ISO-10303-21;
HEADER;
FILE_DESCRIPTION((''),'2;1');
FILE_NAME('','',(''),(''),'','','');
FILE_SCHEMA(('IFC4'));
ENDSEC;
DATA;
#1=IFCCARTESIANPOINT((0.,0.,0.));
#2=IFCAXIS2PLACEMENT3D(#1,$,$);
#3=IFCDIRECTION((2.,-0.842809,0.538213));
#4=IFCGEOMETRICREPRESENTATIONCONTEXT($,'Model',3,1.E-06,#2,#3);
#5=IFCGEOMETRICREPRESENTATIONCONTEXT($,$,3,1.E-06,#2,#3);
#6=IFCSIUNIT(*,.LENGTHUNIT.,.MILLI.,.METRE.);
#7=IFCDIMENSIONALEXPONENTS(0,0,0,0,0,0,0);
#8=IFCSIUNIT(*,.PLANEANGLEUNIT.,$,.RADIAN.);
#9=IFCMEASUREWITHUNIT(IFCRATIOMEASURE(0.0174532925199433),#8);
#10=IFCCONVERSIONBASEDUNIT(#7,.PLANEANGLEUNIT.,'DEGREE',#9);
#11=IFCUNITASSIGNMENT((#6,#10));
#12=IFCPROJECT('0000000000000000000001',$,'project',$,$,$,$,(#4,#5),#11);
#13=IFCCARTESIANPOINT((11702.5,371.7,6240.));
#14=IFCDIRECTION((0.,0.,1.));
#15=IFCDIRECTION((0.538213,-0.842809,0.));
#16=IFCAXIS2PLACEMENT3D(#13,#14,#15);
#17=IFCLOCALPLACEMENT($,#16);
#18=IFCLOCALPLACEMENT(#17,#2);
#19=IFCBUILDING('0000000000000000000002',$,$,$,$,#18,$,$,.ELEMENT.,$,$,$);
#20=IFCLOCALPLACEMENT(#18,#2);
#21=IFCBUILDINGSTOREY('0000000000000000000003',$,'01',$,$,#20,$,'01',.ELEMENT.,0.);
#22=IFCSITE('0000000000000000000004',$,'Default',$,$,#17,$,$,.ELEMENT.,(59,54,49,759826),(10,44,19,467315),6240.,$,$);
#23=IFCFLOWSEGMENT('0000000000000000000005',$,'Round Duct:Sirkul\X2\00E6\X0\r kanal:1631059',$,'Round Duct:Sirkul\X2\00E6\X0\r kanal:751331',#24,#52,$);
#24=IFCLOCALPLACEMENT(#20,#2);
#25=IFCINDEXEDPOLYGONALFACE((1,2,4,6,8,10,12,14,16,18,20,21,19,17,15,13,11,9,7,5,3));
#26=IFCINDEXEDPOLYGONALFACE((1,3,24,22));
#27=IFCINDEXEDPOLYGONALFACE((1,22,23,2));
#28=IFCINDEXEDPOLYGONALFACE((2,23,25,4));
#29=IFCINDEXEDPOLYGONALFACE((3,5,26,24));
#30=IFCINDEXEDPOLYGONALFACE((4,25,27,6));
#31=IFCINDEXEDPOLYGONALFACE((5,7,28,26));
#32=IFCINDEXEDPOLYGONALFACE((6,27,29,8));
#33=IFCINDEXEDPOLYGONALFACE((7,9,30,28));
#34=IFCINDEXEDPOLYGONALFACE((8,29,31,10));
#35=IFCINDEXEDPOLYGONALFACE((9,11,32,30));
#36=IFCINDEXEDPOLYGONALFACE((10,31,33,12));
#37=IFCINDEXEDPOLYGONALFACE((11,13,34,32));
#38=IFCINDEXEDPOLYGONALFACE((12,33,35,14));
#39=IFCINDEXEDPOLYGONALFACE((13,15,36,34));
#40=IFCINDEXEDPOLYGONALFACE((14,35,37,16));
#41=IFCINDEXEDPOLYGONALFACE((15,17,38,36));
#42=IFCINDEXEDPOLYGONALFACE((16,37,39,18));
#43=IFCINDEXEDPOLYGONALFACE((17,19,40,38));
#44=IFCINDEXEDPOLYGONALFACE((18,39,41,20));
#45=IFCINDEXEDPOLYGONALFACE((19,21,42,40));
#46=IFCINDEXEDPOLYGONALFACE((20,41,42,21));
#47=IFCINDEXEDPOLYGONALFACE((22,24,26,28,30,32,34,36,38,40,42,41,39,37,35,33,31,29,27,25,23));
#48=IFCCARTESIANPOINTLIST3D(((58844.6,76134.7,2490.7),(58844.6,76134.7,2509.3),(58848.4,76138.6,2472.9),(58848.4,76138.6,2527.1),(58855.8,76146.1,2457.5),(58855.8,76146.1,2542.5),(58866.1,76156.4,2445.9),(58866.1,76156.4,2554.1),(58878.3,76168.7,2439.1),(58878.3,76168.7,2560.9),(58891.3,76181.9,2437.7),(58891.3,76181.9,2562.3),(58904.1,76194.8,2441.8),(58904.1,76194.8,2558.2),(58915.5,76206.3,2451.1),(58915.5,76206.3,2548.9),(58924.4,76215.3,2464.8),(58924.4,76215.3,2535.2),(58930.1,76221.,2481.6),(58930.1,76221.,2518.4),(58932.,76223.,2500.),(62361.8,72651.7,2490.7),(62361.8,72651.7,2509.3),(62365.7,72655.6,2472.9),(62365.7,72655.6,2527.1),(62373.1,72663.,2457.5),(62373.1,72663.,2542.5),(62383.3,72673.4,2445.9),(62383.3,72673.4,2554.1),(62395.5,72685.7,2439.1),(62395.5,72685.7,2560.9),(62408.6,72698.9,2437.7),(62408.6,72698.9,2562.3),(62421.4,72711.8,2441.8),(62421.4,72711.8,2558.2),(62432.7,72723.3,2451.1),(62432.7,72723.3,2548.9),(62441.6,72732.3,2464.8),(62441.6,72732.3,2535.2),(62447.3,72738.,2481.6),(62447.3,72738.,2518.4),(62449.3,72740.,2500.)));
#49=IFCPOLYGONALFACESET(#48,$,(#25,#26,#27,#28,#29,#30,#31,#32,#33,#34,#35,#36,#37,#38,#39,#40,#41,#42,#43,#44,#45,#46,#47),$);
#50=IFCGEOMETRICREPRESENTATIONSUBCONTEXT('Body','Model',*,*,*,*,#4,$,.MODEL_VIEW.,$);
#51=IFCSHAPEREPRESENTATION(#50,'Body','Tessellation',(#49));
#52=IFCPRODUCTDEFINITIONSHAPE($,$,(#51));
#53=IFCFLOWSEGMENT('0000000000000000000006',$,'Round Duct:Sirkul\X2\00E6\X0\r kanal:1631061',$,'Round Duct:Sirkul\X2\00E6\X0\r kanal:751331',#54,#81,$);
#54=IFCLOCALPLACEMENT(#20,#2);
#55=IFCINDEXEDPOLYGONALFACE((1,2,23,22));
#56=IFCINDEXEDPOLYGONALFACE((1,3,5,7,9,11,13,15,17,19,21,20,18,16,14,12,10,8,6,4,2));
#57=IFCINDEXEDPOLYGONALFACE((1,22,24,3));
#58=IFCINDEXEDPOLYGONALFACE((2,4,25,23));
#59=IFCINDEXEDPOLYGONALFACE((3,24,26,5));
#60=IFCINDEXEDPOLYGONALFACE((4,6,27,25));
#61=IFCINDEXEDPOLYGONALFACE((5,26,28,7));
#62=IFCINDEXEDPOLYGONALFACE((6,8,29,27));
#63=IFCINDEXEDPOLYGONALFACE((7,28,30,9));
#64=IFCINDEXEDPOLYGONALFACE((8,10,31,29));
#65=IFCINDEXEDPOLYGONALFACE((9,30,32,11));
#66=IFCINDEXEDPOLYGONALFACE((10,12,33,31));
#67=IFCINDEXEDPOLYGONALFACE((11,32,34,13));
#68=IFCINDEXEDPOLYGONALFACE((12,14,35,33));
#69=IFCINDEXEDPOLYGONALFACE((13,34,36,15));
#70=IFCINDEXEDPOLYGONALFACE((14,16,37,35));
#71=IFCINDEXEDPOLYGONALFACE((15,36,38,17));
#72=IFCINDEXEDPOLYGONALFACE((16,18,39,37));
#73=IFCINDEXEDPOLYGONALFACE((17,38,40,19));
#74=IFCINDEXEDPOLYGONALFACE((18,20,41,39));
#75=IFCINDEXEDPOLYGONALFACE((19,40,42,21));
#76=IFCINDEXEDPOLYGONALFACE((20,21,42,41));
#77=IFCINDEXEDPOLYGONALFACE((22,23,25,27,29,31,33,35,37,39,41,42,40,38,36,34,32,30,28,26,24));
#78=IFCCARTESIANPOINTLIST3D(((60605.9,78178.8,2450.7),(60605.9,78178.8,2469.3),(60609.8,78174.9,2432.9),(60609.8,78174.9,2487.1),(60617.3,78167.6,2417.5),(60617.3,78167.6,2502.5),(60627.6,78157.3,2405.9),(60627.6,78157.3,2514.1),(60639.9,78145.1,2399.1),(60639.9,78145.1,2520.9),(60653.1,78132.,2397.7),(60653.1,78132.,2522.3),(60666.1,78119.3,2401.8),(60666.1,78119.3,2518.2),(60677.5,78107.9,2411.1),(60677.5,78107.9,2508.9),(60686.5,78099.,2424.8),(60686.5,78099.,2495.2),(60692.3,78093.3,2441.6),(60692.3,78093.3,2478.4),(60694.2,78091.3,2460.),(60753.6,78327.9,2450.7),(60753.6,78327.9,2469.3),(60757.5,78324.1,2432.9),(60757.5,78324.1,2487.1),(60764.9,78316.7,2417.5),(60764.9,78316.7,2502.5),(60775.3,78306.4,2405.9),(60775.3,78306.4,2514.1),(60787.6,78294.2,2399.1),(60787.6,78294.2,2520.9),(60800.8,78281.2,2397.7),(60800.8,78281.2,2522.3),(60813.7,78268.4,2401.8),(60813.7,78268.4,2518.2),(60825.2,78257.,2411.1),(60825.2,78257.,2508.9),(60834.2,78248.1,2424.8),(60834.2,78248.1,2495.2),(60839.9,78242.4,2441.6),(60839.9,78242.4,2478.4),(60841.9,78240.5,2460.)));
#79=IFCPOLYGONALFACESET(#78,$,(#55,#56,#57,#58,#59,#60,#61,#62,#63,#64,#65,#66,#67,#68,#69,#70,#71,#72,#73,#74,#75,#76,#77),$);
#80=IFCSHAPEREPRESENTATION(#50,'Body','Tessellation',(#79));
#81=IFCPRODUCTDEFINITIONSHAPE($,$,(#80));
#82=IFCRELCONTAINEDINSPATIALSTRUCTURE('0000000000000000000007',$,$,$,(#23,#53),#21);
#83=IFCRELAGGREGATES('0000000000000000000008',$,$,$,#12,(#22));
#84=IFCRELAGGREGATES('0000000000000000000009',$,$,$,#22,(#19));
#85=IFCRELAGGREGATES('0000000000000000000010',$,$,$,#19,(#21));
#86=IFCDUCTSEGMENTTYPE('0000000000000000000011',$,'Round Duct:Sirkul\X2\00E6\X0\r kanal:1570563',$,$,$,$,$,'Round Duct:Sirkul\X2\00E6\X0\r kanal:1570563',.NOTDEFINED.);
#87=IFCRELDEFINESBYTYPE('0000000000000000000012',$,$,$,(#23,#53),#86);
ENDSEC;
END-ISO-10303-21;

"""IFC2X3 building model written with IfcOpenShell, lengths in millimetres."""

from ifc_helpers import new_model, entity, si_unit, converted_unit, direction, frame, origin, origin_2d_with_axis, place, context, subcontext, project, spatial, circle, extrude, type_object, element, save


model = new_model("IFC2X3")

# Units and contexts
model_context = context("Model", 3, precision=1e-06, world=origin(), true_north=direction((2.0, -0.842809, 0.538213)))
context_of_model = context(None, 3, precision=1e-06, world=origin(), true_north=direction((2.0, -0.842809, 0.538213)))
body_context = subcontext(model_context, "Body", "Model", "MODEL_VIEW")
ifc_project = project(units=[si_unit("LENGTHUNIT", "METRE", prefix="MILLI"), converted_unit("PLANEANGLEUNIT", "DEGREE", entity("IfcRatioMeasure", 0.0174532925199433), si_unit("PLANEANGLEUNIT", "RADIAN"), dimensions=[0, 0, 0, 0, 0, 0, 0])], contexts=[model_context, context_of_model])

# Site, building, storey
site_placement = place(None, frame((11702.5, 371.7, 6240.0), z_axis=(0.0, 0.0, 1.0), x_axis=(0.538213, -0.842809, 0.0)))
site = spatial("IfcSite", under=ifc_project, at=site_placement, Name="Default", CompositionType="ELEMENT", RefLatitude=(59, 54, 49, 759826), RefLongitude=(10, 44, 19, 467315), RefElevation=6240.0)
building_placement = place(site_placement, origin())
building = spatial("IfcBuilding", under=site, at=building_placement, CompositionType="ELEMENT")
storey_placement = place(building_placement, origin())
storey = spatial("IfcBuildingStorey", under=building, at=storey_placement, Name="01", LongName="01", CompositionType="ELEMENT", Elevation=0.0)

# Flow segments
duct_segment_type = type_object("IfcDuctSegmentType", Name="Round Duct:Sirkulær kanal:1570563", ElementType="Round Duct:Sirkulær kanal:1570563", PredefinedType="NOTDEFINED")
flow_segment_1_placement = place(storey_placement, origin())
element("IfcFlowSegment", 1, at=flow_segment_1_placement, inside=storey, type_object=duct_segment_type, Name="Round Duct:Sirkulær kanal:1631059", ObjectType="Round Duct:Sirkulær kanal:751331", context=body_context, shape_type="SweptSolid", body=[
    extrude(circle(Radius=62.5, at=origin_2d_with_axis()), frame((62405.3, 72695.6, 2500.0), z_axis=(-0.710554, 0.703643, 0.0), x_axis=(0.703643, 0.710554, 0.0)), (0.0, 0.0, 1.0), 4950.0),
])
flow_segment_2_placement = place(storey_placement, origin())
element("IfcFlowSegment", 2, at=flow_segment_2_placement, inside=storey, type_object=duct_segment_type, Name="Round Duct:Sirkulær kanal:1631061", ObjectType="Round Duct:Sirkulær kanal:751331", context=body_context, shape_type="SweptSolid", body=[
    extrude(circle(Radius=62.5, at=origin_2d_with_axis()), frame((60649.8, 78135.3, 2460.0), z_axis=(0.703625, 0.710572, 0.0), x_axis=(0.710572, -0.703625, 0.0)), (0.0, 0.0, 1.0), 209.9),
])

save(model, "model.ifc")
